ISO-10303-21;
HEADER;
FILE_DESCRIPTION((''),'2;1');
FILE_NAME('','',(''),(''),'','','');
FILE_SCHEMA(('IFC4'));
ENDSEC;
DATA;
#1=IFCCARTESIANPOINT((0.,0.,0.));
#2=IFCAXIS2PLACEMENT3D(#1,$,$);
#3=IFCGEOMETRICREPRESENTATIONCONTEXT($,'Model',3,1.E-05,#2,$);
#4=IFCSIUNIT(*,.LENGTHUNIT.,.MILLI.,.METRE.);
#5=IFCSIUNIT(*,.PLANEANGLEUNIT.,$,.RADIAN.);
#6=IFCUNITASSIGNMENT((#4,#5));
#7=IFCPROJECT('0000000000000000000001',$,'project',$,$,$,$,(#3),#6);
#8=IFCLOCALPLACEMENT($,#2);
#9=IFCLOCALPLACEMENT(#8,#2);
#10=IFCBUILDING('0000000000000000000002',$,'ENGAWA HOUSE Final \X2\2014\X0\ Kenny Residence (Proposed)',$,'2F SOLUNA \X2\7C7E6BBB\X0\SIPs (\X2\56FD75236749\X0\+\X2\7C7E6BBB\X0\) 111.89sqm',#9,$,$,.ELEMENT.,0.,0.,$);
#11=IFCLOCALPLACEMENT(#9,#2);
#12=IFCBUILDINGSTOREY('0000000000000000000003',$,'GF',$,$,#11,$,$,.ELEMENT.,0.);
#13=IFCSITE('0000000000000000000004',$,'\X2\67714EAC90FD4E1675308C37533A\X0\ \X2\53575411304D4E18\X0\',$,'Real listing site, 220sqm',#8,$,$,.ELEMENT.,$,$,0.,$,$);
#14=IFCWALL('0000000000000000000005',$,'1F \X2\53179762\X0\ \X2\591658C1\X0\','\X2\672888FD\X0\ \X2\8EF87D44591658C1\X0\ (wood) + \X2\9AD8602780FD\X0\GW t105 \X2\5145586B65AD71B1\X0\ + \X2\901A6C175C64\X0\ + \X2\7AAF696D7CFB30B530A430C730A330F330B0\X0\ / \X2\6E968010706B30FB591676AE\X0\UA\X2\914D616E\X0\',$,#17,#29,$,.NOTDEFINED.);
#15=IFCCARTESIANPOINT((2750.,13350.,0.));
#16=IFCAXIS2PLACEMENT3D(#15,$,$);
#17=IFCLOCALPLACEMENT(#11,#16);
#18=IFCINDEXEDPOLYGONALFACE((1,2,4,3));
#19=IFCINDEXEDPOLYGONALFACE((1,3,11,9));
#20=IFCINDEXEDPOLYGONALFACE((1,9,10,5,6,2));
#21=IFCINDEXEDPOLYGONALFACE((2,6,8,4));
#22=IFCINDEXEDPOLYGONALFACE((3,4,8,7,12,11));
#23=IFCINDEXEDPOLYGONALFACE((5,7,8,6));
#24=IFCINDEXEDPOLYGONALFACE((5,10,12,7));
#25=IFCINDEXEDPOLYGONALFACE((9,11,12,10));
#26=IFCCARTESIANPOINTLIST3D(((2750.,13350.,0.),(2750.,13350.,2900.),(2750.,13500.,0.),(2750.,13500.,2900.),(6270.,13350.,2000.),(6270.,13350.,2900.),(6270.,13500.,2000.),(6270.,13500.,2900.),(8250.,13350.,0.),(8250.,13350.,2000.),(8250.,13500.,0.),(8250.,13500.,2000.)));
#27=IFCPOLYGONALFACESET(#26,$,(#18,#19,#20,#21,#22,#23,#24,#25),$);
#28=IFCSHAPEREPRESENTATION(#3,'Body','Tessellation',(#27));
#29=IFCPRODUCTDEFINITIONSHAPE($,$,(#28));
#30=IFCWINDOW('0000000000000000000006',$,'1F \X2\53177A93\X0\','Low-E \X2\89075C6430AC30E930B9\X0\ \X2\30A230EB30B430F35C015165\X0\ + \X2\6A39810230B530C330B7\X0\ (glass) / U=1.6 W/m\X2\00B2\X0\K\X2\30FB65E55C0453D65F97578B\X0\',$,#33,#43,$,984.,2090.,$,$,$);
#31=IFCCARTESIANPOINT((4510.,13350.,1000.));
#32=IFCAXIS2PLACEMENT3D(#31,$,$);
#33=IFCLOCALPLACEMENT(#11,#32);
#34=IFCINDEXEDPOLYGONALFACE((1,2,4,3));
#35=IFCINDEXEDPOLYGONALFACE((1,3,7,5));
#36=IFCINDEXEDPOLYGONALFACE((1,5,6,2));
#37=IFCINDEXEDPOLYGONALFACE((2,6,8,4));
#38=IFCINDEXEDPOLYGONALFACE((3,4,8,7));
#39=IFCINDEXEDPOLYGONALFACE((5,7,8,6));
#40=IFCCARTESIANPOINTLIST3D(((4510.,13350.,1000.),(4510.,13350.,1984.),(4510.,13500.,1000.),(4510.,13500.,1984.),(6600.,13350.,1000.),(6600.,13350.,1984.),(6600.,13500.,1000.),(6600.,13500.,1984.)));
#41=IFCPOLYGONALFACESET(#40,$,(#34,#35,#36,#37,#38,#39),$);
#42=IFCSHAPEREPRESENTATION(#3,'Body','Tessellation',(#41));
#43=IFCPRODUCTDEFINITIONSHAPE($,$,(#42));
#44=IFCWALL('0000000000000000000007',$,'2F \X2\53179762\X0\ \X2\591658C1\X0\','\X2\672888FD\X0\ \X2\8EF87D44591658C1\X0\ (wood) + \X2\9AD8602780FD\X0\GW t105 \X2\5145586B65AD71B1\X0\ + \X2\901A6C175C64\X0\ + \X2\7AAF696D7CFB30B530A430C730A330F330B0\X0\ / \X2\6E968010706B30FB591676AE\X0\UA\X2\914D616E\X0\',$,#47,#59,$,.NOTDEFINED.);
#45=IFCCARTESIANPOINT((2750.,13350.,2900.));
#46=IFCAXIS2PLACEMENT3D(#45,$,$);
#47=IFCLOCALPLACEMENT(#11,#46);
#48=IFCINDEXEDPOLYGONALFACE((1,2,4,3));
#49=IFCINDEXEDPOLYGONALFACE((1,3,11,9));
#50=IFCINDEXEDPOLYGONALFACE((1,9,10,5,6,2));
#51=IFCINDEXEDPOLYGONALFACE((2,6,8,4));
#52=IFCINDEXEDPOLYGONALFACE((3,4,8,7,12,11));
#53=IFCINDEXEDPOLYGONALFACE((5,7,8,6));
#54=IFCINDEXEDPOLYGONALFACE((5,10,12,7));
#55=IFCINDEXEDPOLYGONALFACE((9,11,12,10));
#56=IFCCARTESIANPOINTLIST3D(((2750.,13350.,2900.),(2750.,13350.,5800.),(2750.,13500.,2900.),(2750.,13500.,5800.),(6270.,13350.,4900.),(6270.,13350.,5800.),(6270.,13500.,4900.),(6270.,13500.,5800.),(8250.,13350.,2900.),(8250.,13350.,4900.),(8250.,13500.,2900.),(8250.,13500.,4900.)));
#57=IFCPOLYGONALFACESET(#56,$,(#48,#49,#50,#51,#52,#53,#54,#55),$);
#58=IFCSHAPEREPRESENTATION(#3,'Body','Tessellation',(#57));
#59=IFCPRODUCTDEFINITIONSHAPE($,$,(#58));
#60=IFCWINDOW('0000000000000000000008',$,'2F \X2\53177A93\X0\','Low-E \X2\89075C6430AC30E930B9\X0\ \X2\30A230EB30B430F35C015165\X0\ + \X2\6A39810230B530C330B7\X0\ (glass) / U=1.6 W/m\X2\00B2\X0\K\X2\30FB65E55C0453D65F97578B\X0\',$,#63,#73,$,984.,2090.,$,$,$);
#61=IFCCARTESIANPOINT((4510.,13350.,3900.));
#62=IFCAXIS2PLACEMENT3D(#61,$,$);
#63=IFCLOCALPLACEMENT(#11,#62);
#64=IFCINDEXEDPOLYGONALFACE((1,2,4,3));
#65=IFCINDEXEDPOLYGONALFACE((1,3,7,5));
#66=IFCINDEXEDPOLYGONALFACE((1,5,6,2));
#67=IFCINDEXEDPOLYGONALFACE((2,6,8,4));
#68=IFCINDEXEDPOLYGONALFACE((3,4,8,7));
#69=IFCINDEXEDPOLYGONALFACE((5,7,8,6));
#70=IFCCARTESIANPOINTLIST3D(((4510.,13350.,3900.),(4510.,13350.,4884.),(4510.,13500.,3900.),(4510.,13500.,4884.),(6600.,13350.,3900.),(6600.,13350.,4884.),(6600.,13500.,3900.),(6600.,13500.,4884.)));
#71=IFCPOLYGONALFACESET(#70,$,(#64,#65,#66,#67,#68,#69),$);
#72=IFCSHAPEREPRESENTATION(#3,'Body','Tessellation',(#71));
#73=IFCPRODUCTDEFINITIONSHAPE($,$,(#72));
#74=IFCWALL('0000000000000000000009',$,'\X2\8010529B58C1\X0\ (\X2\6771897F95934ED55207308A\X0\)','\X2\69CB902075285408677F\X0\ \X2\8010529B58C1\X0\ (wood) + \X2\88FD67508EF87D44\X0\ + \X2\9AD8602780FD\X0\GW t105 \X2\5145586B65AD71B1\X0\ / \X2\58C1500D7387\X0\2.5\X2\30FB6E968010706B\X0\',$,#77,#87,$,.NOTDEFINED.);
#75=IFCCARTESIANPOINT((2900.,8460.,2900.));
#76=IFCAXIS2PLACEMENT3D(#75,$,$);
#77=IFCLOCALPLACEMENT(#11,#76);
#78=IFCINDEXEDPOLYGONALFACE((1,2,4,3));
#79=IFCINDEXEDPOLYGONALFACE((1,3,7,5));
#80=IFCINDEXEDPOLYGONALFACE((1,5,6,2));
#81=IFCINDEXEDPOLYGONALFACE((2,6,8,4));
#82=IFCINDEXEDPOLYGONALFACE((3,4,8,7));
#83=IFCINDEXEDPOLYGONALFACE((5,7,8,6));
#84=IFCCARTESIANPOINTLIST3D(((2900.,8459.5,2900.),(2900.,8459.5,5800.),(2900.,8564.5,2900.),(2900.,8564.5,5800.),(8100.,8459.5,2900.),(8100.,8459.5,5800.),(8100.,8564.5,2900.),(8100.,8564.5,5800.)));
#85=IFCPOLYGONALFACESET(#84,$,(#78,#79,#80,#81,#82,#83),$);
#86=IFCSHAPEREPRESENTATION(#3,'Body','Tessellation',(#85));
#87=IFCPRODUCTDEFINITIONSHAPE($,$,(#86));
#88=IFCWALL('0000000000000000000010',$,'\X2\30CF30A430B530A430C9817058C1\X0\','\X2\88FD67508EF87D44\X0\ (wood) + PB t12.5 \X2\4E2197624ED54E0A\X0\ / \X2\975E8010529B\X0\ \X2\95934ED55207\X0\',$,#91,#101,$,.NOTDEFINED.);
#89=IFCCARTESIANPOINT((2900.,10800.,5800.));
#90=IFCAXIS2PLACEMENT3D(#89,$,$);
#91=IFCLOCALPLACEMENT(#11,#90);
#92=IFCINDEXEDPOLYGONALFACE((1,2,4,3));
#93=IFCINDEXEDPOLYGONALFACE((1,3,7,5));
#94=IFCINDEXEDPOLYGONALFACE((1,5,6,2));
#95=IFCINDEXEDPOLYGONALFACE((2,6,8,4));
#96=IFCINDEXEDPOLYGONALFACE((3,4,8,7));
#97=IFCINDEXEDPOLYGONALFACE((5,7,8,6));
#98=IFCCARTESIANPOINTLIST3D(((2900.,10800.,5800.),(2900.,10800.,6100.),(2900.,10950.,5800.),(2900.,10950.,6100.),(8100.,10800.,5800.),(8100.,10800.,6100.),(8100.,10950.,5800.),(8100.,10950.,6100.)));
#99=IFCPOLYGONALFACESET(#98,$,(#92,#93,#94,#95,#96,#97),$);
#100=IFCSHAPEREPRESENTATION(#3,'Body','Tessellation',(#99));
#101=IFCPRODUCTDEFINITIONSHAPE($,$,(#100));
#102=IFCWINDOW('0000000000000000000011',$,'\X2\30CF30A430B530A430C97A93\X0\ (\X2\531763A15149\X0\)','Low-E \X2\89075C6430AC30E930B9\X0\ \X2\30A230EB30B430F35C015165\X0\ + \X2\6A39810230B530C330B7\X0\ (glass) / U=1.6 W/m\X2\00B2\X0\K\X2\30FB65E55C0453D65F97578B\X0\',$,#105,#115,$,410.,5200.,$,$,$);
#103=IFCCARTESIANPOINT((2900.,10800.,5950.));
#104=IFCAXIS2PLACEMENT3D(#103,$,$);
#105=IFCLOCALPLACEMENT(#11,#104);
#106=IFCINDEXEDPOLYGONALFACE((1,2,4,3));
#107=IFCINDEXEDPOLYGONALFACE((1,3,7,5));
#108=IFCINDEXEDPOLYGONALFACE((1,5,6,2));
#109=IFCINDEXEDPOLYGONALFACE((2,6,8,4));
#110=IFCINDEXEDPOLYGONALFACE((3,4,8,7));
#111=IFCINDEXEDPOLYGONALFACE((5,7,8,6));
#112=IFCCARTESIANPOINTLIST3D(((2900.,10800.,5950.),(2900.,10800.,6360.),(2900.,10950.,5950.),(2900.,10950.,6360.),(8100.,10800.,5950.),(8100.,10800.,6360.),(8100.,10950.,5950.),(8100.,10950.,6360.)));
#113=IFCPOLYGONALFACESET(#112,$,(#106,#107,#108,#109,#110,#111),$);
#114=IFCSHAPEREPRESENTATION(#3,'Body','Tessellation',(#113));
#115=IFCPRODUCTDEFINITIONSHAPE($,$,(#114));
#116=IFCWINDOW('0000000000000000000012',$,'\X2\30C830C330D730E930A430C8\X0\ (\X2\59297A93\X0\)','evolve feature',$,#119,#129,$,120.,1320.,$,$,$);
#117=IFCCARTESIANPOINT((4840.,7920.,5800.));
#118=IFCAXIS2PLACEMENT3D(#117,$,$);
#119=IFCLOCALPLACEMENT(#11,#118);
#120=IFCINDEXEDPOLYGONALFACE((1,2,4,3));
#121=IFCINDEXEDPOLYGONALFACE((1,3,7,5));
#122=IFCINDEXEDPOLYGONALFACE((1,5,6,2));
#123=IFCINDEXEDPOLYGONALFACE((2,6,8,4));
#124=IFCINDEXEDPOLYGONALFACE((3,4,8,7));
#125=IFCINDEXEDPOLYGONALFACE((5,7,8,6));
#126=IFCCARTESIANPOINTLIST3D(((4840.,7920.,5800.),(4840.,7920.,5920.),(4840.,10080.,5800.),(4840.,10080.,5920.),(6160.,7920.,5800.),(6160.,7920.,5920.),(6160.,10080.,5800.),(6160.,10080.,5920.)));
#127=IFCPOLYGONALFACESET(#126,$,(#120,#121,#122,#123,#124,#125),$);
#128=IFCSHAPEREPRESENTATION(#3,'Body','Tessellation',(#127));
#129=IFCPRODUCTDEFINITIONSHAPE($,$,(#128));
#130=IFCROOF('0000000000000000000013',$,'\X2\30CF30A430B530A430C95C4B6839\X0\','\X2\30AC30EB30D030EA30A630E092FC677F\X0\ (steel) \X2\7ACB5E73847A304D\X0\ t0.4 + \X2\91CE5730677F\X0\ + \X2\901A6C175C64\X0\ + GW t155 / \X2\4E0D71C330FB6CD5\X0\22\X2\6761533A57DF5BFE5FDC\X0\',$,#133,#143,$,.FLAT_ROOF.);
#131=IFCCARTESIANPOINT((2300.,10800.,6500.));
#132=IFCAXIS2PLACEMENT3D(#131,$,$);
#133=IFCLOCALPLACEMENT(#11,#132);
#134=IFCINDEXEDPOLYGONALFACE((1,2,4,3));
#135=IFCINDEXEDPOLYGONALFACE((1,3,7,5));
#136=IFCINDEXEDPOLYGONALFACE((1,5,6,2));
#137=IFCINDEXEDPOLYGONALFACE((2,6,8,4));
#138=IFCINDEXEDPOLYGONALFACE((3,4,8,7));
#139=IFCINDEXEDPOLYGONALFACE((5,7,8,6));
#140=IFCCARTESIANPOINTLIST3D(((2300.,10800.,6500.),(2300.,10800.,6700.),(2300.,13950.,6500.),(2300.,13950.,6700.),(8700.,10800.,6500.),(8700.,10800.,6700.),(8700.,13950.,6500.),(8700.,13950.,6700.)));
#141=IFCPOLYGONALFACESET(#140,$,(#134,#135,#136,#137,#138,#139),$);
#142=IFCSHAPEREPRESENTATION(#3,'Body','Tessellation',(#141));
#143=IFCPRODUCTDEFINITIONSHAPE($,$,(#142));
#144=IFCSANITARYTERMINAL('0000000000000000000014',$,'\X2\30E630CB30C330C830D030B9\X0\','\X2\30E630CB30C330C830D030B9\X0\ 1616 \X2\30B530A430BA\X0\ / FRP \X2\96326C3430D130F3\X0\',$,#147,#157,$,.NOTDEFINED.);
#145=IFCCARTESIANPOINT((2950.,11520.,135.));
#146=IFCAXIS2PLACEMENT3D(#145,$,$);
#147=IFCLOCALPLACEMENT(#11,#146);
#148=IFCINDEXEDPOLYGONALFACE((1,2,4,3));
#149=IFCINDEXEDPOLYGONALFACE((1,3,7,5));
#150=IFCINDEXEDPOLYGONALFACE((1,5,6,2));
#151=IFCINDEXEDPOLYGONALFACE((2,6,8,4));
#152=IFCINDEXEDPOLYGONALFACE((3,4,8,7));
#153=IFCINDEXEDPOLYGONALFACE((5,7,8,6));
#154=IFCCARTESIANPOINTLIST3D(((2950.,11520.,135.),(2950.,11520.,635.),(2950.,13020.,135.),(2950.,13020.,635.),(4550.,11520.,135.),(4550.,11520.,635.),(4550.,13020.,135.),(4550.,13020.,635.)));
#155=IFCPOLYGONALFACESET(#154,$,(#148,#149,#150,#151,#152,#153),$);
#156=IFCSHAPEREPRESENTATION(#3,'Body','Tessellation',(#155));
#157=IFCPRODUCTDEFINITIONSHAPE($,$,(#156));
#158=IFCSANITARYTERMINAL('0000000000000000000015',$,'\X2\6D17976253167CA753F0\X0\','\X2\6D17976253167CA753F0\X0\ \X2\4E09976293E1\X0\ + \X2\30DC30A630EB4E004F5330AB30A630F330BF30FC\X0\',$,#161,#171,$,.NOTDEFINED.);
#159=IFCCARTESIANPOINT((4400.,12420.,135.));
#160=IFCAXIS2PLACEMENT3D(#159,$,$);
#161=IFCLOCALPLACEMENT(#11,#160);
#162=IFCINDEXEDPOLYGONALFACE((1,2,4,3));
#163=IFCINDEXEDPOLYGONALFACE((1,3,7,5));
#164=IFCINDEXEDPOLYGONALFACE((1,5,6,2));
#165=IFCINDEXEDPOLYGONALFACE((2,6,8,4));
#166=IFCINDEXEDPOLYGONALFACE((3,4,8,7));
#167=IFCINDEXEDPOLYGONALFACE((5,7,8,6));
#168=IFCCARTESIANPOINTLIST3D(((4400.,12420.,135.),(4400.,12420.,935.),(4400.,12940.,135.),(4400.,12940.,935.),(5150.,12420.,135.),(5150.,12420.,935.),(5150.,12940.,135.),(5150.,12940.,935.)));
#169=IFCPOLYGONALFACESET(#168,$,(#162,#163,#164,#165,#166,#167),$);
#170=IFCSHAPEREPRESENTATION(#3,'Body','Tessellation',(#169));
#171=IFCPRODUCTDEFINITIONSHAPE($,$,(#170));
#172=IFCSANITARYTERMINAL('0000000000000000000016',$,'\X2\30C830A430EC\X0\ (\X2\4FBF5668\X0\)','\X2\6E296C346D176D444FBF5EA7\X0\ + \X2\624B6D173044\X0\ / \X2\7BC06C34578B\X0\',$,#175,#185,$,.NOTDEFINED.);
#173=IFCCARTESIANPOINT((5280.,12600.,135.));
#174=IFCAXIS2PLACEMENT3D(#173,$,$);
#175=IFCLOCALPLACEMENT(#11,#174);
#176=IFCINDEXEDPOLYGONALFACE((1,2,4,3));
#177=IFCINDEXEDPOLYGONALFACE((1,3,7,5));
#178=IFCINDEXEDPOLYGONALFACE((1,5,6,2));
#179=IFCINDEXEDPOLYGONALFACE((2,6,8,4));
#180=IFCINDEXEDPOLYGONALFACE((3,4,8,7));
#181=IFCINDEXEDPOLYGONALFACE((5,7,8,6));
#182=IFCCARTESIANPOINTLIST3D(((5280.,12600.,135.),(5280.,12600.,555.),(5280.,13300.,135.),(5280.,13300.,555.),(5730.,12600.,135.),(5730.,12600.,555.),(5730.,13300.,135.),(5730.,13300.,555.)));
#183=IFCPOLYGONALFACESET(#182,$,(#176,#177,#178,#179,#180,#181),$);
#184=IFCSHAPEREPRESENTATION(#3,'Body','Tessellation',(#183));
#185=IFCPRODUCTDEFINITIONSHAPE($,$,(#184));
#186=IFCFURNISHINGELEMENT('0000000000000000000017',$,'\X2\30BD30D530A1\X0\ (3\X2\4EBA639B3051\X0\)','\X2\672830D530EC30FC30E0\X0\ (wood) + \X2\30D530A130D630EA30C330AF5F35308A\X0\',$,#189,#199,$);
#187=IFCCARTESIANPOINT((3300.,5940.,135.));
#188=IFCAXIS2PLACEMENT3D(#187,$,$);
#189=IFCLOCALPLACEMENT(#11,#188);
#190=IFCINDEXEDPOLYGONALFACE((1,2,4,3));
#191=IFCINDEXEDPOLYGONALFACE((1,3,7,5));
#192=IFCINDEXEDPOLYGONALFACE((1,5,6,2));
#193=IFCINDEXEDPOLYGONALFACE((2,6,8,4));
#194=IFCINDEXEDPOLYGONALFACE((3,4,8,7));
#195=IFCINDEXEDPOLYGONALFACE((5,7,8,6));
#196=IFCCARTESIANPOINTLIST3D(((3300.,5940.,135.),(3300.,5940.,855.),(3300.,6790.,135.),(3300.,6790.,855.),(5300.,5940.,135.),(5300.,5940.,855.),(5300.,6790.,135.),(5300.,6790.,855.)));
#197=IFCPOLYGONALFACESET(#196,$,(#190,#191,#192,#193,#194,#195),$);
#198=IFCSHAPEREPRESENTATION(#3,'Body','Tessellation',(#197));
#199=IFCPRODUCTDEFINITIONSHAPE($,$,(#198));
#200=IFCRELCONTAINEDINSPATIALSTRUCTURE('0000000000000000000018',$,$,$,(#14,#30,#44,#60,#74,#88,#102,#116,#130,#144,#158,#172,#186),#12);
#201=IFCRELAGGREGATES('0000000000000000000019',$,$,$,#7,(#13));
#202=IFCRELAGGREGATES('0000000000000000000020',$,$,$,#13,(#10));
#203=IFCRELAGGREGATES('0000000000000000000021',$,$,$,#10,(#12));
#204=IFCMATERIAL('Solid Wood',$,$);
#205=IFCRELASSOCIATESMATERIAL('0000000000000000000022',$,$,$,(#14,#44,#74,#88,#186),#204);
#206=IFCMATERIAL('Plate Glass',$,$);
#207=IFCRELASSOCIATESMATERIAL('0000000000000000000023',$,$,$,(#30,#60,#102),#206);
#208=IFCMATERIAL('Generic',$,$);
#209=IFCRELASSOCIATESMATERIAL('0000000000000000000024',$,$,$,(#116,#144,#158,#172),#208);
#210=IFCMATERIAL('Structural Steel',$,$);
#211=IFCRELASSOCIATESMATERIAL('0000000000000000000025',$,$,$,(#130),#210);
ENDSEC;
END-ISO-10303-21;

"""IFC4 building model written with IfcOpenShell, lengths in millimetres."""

from ifc_helpers import new_model, si_unit, frame, frame_2d, origin, place, context, project, spatial, rectangle, extrude, material, element, fill, save


model = new_model("IFC4")

# Units and contexts
model_context = context("Model", 3, precision=1e-05, world=origin())
ifc_project = project(units=[si_unit("LENGTHUNIT", "METRE", prefix="MILLI"), si_unit("PLANEANGLEUNIT", "RADIAN")], contexts=[model_context])

# Site, building, storey
site_placement = place(None, origin())
site = spatial("IfcSite", under=ifc_project, at=site_placement, Name="東京都世田谷区 南向き丘", ObjectType="Real listing site, 220sqm", CompositionType="ELEMENT", RefElevation=0.0)
building_placement = place(site_placement, origin())
building = spatial("IfcBuilding", under=site, at=building_placement, Name="ENGAWA HOUSE Final — Kenny Residence (Proposed)", ObjectType="2F SOLUNA 籾殻SIPs (国産杉+籾殻) 111.89sqm", CompositionType="ELEMENT", ElevationOfRefHeight=0.0, ElevationOfTerrain=0.0)
storey_placement = place(building_placement, origin())
storey = spatial("IfcBuildingStorey", under=building, at=storey_placement, Name="GF", CompositionType="ELEMENT", Elevation=0.0)

# Wall, opening, window
ifc_material_1 = material(Name="Solid Wood")
wall_1_placement = place(storey_placement, frame((2750.0, 13350.0, 0.0)))
wall_1 = element("IfcWall", 1, at=wall_1_placement, inside=storey, material=ifc_material_1, Name="1F 北面 外壁", Description="木製 軸組外壁 (wood) + 高性能GW t105 充填断熱 + 通気層 + 窯業系サイディング / 準耐火・外皮UA配慮", PredefinedType="NOTDEFINED", context=model_context, shape_type="SweptSolid", body=[
    extrude(rectangle(XDim=5500.0, YDim=150.0, at=frame_2d((2750.0, 75.0))), frame((2750.0, 13350.0, 0.0)), (0.0, 0.0, 1.0), 2900.0),
])
opening_1_placement = place(storey_placement, frame((4510.0, 13350.0, 1000.0)))
opening_1 = element("IfcOpeningElement", 2, at=opening_1_placement, cuts=wall_1, PredefinedType="NOTDEFINED", context=model_context, shape_type="SweptSolid", body=[
    extrude(rectangle(XDim=2090.0, YDim=150.0, at=frame_2d((1045.0, 75.0))), frame((4510.0, 13350.0, 1000.0)), (0.0, 0.0, 1.0), 984.0),
])
ifc_material_2 = material(Name="Plate Glass")
window_1_placement = place(storey_placement, frame((4510.0, 13350.0, 1000.0)))
window_1 = element("IfcWindow", 3, at=window_1_placement, inside=storey, material=ifc_material_2, Name="1F 北窓", Description="Low-E 複層ガラス アルゴン封入 + 樹脂サッシ (glass) / U=1.6 W/m²K・日射取得型", OverallHeight=984.0, OverallWidth=2090.0, context=model_context, shape_type="SweptSolid", body=[
    extrude(rectangle(XDim=2090.0, YDim=150.0, at=frame_2d((1045.0, 75.0))), frame((4510.0, 13350.0, 1000.0)), (0.0, 0.0, 1.0), 984.0),
])
fill(opening_1, window_1)

# Wall, opening, window
wall_2_placement = place(storey_placement, frame((2750.0, 13350.0, 2900.0)))
wall_2 = element("IfcWall", 4, at=wall_2_placement, inside=storey, material=ifc_material_1, Name="2F 北面 外壁", Description="木製 軸組外壁 (wood) + 高性能GW t105 充填断熱 + 通気層 + 窯業系サイディング / 準耐火・外皮UA配慮", PredefinedType="NOTDEFINED", context=model_context, shape_type="SweptSolid", body=[
    extrude(rectangle(XDim=5500.0, YDim=150.0, at=frame_2d((2750.0, 75.0))), frame((2750.0, 13350.0, 2900.0)), (0.0, 0.0, 1.0), 2900.0),
])
opening_2_placement = place(storey_placement, frame((4510.0, 13350.0, 3900.0)))
opening_2 = element("IfcOpeningElement", 5, at=opening_2_placement, cuts=wall_2, PredefinedType="NOTDEFINED", context=model_context, shape_type="SweptSolid", body=[
    extrude(rectangle(XDim=2090.0, YDim=150.0, at=frame_2d((1045.0, 75.0))), frame((4510.0, 13350.0, 3900.0)), (0.0, 0.0, 1.0), 984.0),
])
window_2_placement = place(storey_placement, frame((4510.0, 13350.0, 3900.0)))
window_2 = element("IfcWindow", 6, at=window_2_placement, inside=storey, material=ifc_material_2, Name="2F 北窓", Description="Low-E 複層ガラス アルゴン封入 + 樹脂サッシ (glass) / U=1.6 W/m²K・日射取得型", OverallHeight=984.0, OverallWidth=2090.0, context=model_context, shape_type="SweptSolid", body=[
    extrude(rectangle(XDim=2090.0, YDim=150.0, at=frame_2d((1045.0, 75.0))), frame((4510.0, 13350.0, 3900.0)), (0.0, 0.0, 1.0), 984.0),
])
fill(opening_2, window_2)

# Wall
wall_3_placement = place(storey_placement, frame((2900.0, 8460.0, 2900.0)))
element("IfcWall", 7, at=wall_3_placement, inside=storey, material=ifc_material_1, Name="耐力壁 (東西間仕切り)", Description="構造用合板 耐力壁 (wood) + 製材軸組 + 高性能GW t105 充填断熱 / 壁倍率2.5・準耐火", PredefinedType="NOTDEFINED", context=model_context, shape_type="SweptSolid", body=[
    extrude(rectangle(XDim=5200.0, YDim=105.0, at=frame_2d((2600.0, 52.0))), frame((2900.0, 8460.0, 2900.0)), (0.0, 0.0, 1.0), 2900.0),
])

# Wall, opening, window
wall_4_placement = place(storey_placement, frame((2900.0, 10800.0, 5800.0)))
wall_4 = element("IfcWall", 8, at=wall_4_placement, inside=storey, material=ifc_material_1, Name="ハイサイド腰壁", Description="製材軸組 (wood) + PB t12.5 両面仕上 / 非耐力 間仕切", PredefinedType="NOTDEFINED", context=model_context, shape_type="SweptSolid", body=[
    extrude(rectangle(XDim=5200.0, YDim=150.0, at=frame_2d((2600.0, 75.0))), frame((2900.0, 10800.0, 5800.0)), (0.0, 0.0, 1.0), 700.0),
])
opening_3_placement = place(storey_placement, frame((2900.0, 10800.0, 5950.0)))
opening_3 = element("IfcOpeningElement", 9, at=opening_3_placement, cuts=wall_4, PredefinedType="NOTDEFINED", context=model_context, shape_type="SweptSolid", body=[
    extrude(rectangle(XDim=5200.0, YDim=150.0, at=frame_2d((2600.0, 75.0))), frame((2900.0, 10800.0, 5950.0)), (0.0, 0.0, 1.0), 410.0),
])
window_3_placement = place(storey_placement, frame((2900.0, 10800.0, 5950.0)))
window_3 = element("IfcWindow", 10, at=window_3_placement, inside=storey, material=ifc_material_2, Name="ハイサイド窓 (北採光)", Description="Low-E 複層ガラス アルゴン封入 + 樹脂サッシ (glass) / U=1.6 W/m²K・日射取得型", OverallHeight=410.0, OverallWidth=5200.0, context=model_context, shape_type="SweptSolid", body=[
    extrude(rectangle(XDim=5200.0, YDim=150.0, at=frame_2d((2600.0, 75.0))), frame((2900.0, 10800.0, 5950.0)), (0.0, 0.0, 1.0), 410.0),
])
fill(opening_3, window_3)

# Window
ifc_material_3 = material(Name="Generic")
window_4_placement = place(storey_placement, frame((4840.0, 7920.0, 5800.0)))
element("IfcWindow", 11, at=window_4_placement, inside=storey, material=ifc_material_3, Name="トップライト (天窓)", Description="evolve feature", OverallHeight=120.0, OverallWidth=1320.0, context=model_context, shape_type="SweptSolid", body=[
    extrude(rectangle(XDim=1320.0, YDim=2160.0, at=frame_2d((660.0, 1080.0))), frame((4840.0, 7920.0, 5800.0)), (0.0, 0.0, 1.0), 120.0),
])

# Roof
ifc_material_4 = material(Name="Structural Steel")
roof_placement = place(storey_placement, frame((2300.0, 10800.0, 6500.0)))
element("IfcRoof", 12, at=roof_placement, inside=storey, material=ifc_material_4, Name="ハイサイド屋根", Description="ガルバリウム鋼板 (steel) 立平葺き t0.4 + 野地板 + 通気層 + GW t155 / 不燃・法22条区域対応", PredefinedType="FLAT_ROOF", context=model_context, shape_type="SweptSolid", body=[
    extrude(rectangle(XDim=6400.0, YDim=3150.0, at=frame_2d((3200.0, 1575.0))), frame((2300.0, 10800.0, 6500.0)), (0.0, 0.0, 1.0), 200.0),
])

# Sanitary terminals
sanitary_terminal_1_placement = place(storey_placement, frame((2950.0, 11520.0, 135.0)))
element("IfcSanitaryTerminal", 13, at=sanitary_terminal_1_placement, inside=storey, material=ifc_material_3, Name="ユニットバス", Description="ユニットバス 1616 サイズ / FRP 防水パン", PredefinedType="NOTDEFINED", context=model_context, shape_type="SweptSolid", body=[
    extrude(rectangle(XDim=1600.0, YDim=1500.0, at=frame_2d((800.0, 750.0))), frame((2950.0, 11520.0, 135.0)), (0.0, 0.0, 1.0), 500.0),
])
sanitary_terminal_2_placement = place(storey_placement, frame((4400.0, 12420.0, 135.0)))
element("IfcSanitaryTerminal", 14, at=sanitary_terminal_2_placement, inside=storey, material=ifc_material_3, Name="洗面化粧台", Description="洗面化粧台 三面鏡 + ボウル一体カウンター", PredefinedType="NOTDEFINED", context=model_context, shape_type="SweptSolid", body=[
    extrude(rectangle(XDim=750.0, YDim=520.0, at=frame_2d((375.0, 260.0))), frame((4400.0, 12420.0, 135.0)), (0.0, 0.0, 1.0), 800.0),
])
sanitary_terminal_3_placement = place(storey_placement, frame((5280.0, 12600.0, 135.0)))
element("IfcSanitaryTerminal", 15, at=sanitary_terminal_3_placement, inside=storey, material=ifc_material_3, Name="トイレ (便器)", Description="温水洗浄便座 + 手洗い / 節水型", PredefinedType="NOTDEFINED", context=model_context, shape_type="SweptSolid", body=[
    extrude(rectangle(XDim=450.0, YDim=700.0, at=frame_2d((225.0, 350.0))), frame((5280.0, 12600.0, 135.0)), (0.0, 0.0, 1.0), 420.0),
])

# Furnishing element
furnishing_1_placement = place(storey_placement, frame((3300.0, 5940.0, 135.0)))
element("IfcFurnishingElement", 16, at=furnishing_1_placement, inside=storey, material=ifc_material_1, Name="ソファ (3人掛け)", Description="木フレーム (wood) + ファブリック張り", context=model_context, shape_type="SweptSolid", body=[
    extrude(rectangle(XDim=2000.0, YDim=850.0, at=frame_2d((1000.0, 425.0))), frame((3300.0, 5940.0, 135.0)), (0.0, 0.0, 1.0), 720.0),
])

save(model, "model.ifc")
